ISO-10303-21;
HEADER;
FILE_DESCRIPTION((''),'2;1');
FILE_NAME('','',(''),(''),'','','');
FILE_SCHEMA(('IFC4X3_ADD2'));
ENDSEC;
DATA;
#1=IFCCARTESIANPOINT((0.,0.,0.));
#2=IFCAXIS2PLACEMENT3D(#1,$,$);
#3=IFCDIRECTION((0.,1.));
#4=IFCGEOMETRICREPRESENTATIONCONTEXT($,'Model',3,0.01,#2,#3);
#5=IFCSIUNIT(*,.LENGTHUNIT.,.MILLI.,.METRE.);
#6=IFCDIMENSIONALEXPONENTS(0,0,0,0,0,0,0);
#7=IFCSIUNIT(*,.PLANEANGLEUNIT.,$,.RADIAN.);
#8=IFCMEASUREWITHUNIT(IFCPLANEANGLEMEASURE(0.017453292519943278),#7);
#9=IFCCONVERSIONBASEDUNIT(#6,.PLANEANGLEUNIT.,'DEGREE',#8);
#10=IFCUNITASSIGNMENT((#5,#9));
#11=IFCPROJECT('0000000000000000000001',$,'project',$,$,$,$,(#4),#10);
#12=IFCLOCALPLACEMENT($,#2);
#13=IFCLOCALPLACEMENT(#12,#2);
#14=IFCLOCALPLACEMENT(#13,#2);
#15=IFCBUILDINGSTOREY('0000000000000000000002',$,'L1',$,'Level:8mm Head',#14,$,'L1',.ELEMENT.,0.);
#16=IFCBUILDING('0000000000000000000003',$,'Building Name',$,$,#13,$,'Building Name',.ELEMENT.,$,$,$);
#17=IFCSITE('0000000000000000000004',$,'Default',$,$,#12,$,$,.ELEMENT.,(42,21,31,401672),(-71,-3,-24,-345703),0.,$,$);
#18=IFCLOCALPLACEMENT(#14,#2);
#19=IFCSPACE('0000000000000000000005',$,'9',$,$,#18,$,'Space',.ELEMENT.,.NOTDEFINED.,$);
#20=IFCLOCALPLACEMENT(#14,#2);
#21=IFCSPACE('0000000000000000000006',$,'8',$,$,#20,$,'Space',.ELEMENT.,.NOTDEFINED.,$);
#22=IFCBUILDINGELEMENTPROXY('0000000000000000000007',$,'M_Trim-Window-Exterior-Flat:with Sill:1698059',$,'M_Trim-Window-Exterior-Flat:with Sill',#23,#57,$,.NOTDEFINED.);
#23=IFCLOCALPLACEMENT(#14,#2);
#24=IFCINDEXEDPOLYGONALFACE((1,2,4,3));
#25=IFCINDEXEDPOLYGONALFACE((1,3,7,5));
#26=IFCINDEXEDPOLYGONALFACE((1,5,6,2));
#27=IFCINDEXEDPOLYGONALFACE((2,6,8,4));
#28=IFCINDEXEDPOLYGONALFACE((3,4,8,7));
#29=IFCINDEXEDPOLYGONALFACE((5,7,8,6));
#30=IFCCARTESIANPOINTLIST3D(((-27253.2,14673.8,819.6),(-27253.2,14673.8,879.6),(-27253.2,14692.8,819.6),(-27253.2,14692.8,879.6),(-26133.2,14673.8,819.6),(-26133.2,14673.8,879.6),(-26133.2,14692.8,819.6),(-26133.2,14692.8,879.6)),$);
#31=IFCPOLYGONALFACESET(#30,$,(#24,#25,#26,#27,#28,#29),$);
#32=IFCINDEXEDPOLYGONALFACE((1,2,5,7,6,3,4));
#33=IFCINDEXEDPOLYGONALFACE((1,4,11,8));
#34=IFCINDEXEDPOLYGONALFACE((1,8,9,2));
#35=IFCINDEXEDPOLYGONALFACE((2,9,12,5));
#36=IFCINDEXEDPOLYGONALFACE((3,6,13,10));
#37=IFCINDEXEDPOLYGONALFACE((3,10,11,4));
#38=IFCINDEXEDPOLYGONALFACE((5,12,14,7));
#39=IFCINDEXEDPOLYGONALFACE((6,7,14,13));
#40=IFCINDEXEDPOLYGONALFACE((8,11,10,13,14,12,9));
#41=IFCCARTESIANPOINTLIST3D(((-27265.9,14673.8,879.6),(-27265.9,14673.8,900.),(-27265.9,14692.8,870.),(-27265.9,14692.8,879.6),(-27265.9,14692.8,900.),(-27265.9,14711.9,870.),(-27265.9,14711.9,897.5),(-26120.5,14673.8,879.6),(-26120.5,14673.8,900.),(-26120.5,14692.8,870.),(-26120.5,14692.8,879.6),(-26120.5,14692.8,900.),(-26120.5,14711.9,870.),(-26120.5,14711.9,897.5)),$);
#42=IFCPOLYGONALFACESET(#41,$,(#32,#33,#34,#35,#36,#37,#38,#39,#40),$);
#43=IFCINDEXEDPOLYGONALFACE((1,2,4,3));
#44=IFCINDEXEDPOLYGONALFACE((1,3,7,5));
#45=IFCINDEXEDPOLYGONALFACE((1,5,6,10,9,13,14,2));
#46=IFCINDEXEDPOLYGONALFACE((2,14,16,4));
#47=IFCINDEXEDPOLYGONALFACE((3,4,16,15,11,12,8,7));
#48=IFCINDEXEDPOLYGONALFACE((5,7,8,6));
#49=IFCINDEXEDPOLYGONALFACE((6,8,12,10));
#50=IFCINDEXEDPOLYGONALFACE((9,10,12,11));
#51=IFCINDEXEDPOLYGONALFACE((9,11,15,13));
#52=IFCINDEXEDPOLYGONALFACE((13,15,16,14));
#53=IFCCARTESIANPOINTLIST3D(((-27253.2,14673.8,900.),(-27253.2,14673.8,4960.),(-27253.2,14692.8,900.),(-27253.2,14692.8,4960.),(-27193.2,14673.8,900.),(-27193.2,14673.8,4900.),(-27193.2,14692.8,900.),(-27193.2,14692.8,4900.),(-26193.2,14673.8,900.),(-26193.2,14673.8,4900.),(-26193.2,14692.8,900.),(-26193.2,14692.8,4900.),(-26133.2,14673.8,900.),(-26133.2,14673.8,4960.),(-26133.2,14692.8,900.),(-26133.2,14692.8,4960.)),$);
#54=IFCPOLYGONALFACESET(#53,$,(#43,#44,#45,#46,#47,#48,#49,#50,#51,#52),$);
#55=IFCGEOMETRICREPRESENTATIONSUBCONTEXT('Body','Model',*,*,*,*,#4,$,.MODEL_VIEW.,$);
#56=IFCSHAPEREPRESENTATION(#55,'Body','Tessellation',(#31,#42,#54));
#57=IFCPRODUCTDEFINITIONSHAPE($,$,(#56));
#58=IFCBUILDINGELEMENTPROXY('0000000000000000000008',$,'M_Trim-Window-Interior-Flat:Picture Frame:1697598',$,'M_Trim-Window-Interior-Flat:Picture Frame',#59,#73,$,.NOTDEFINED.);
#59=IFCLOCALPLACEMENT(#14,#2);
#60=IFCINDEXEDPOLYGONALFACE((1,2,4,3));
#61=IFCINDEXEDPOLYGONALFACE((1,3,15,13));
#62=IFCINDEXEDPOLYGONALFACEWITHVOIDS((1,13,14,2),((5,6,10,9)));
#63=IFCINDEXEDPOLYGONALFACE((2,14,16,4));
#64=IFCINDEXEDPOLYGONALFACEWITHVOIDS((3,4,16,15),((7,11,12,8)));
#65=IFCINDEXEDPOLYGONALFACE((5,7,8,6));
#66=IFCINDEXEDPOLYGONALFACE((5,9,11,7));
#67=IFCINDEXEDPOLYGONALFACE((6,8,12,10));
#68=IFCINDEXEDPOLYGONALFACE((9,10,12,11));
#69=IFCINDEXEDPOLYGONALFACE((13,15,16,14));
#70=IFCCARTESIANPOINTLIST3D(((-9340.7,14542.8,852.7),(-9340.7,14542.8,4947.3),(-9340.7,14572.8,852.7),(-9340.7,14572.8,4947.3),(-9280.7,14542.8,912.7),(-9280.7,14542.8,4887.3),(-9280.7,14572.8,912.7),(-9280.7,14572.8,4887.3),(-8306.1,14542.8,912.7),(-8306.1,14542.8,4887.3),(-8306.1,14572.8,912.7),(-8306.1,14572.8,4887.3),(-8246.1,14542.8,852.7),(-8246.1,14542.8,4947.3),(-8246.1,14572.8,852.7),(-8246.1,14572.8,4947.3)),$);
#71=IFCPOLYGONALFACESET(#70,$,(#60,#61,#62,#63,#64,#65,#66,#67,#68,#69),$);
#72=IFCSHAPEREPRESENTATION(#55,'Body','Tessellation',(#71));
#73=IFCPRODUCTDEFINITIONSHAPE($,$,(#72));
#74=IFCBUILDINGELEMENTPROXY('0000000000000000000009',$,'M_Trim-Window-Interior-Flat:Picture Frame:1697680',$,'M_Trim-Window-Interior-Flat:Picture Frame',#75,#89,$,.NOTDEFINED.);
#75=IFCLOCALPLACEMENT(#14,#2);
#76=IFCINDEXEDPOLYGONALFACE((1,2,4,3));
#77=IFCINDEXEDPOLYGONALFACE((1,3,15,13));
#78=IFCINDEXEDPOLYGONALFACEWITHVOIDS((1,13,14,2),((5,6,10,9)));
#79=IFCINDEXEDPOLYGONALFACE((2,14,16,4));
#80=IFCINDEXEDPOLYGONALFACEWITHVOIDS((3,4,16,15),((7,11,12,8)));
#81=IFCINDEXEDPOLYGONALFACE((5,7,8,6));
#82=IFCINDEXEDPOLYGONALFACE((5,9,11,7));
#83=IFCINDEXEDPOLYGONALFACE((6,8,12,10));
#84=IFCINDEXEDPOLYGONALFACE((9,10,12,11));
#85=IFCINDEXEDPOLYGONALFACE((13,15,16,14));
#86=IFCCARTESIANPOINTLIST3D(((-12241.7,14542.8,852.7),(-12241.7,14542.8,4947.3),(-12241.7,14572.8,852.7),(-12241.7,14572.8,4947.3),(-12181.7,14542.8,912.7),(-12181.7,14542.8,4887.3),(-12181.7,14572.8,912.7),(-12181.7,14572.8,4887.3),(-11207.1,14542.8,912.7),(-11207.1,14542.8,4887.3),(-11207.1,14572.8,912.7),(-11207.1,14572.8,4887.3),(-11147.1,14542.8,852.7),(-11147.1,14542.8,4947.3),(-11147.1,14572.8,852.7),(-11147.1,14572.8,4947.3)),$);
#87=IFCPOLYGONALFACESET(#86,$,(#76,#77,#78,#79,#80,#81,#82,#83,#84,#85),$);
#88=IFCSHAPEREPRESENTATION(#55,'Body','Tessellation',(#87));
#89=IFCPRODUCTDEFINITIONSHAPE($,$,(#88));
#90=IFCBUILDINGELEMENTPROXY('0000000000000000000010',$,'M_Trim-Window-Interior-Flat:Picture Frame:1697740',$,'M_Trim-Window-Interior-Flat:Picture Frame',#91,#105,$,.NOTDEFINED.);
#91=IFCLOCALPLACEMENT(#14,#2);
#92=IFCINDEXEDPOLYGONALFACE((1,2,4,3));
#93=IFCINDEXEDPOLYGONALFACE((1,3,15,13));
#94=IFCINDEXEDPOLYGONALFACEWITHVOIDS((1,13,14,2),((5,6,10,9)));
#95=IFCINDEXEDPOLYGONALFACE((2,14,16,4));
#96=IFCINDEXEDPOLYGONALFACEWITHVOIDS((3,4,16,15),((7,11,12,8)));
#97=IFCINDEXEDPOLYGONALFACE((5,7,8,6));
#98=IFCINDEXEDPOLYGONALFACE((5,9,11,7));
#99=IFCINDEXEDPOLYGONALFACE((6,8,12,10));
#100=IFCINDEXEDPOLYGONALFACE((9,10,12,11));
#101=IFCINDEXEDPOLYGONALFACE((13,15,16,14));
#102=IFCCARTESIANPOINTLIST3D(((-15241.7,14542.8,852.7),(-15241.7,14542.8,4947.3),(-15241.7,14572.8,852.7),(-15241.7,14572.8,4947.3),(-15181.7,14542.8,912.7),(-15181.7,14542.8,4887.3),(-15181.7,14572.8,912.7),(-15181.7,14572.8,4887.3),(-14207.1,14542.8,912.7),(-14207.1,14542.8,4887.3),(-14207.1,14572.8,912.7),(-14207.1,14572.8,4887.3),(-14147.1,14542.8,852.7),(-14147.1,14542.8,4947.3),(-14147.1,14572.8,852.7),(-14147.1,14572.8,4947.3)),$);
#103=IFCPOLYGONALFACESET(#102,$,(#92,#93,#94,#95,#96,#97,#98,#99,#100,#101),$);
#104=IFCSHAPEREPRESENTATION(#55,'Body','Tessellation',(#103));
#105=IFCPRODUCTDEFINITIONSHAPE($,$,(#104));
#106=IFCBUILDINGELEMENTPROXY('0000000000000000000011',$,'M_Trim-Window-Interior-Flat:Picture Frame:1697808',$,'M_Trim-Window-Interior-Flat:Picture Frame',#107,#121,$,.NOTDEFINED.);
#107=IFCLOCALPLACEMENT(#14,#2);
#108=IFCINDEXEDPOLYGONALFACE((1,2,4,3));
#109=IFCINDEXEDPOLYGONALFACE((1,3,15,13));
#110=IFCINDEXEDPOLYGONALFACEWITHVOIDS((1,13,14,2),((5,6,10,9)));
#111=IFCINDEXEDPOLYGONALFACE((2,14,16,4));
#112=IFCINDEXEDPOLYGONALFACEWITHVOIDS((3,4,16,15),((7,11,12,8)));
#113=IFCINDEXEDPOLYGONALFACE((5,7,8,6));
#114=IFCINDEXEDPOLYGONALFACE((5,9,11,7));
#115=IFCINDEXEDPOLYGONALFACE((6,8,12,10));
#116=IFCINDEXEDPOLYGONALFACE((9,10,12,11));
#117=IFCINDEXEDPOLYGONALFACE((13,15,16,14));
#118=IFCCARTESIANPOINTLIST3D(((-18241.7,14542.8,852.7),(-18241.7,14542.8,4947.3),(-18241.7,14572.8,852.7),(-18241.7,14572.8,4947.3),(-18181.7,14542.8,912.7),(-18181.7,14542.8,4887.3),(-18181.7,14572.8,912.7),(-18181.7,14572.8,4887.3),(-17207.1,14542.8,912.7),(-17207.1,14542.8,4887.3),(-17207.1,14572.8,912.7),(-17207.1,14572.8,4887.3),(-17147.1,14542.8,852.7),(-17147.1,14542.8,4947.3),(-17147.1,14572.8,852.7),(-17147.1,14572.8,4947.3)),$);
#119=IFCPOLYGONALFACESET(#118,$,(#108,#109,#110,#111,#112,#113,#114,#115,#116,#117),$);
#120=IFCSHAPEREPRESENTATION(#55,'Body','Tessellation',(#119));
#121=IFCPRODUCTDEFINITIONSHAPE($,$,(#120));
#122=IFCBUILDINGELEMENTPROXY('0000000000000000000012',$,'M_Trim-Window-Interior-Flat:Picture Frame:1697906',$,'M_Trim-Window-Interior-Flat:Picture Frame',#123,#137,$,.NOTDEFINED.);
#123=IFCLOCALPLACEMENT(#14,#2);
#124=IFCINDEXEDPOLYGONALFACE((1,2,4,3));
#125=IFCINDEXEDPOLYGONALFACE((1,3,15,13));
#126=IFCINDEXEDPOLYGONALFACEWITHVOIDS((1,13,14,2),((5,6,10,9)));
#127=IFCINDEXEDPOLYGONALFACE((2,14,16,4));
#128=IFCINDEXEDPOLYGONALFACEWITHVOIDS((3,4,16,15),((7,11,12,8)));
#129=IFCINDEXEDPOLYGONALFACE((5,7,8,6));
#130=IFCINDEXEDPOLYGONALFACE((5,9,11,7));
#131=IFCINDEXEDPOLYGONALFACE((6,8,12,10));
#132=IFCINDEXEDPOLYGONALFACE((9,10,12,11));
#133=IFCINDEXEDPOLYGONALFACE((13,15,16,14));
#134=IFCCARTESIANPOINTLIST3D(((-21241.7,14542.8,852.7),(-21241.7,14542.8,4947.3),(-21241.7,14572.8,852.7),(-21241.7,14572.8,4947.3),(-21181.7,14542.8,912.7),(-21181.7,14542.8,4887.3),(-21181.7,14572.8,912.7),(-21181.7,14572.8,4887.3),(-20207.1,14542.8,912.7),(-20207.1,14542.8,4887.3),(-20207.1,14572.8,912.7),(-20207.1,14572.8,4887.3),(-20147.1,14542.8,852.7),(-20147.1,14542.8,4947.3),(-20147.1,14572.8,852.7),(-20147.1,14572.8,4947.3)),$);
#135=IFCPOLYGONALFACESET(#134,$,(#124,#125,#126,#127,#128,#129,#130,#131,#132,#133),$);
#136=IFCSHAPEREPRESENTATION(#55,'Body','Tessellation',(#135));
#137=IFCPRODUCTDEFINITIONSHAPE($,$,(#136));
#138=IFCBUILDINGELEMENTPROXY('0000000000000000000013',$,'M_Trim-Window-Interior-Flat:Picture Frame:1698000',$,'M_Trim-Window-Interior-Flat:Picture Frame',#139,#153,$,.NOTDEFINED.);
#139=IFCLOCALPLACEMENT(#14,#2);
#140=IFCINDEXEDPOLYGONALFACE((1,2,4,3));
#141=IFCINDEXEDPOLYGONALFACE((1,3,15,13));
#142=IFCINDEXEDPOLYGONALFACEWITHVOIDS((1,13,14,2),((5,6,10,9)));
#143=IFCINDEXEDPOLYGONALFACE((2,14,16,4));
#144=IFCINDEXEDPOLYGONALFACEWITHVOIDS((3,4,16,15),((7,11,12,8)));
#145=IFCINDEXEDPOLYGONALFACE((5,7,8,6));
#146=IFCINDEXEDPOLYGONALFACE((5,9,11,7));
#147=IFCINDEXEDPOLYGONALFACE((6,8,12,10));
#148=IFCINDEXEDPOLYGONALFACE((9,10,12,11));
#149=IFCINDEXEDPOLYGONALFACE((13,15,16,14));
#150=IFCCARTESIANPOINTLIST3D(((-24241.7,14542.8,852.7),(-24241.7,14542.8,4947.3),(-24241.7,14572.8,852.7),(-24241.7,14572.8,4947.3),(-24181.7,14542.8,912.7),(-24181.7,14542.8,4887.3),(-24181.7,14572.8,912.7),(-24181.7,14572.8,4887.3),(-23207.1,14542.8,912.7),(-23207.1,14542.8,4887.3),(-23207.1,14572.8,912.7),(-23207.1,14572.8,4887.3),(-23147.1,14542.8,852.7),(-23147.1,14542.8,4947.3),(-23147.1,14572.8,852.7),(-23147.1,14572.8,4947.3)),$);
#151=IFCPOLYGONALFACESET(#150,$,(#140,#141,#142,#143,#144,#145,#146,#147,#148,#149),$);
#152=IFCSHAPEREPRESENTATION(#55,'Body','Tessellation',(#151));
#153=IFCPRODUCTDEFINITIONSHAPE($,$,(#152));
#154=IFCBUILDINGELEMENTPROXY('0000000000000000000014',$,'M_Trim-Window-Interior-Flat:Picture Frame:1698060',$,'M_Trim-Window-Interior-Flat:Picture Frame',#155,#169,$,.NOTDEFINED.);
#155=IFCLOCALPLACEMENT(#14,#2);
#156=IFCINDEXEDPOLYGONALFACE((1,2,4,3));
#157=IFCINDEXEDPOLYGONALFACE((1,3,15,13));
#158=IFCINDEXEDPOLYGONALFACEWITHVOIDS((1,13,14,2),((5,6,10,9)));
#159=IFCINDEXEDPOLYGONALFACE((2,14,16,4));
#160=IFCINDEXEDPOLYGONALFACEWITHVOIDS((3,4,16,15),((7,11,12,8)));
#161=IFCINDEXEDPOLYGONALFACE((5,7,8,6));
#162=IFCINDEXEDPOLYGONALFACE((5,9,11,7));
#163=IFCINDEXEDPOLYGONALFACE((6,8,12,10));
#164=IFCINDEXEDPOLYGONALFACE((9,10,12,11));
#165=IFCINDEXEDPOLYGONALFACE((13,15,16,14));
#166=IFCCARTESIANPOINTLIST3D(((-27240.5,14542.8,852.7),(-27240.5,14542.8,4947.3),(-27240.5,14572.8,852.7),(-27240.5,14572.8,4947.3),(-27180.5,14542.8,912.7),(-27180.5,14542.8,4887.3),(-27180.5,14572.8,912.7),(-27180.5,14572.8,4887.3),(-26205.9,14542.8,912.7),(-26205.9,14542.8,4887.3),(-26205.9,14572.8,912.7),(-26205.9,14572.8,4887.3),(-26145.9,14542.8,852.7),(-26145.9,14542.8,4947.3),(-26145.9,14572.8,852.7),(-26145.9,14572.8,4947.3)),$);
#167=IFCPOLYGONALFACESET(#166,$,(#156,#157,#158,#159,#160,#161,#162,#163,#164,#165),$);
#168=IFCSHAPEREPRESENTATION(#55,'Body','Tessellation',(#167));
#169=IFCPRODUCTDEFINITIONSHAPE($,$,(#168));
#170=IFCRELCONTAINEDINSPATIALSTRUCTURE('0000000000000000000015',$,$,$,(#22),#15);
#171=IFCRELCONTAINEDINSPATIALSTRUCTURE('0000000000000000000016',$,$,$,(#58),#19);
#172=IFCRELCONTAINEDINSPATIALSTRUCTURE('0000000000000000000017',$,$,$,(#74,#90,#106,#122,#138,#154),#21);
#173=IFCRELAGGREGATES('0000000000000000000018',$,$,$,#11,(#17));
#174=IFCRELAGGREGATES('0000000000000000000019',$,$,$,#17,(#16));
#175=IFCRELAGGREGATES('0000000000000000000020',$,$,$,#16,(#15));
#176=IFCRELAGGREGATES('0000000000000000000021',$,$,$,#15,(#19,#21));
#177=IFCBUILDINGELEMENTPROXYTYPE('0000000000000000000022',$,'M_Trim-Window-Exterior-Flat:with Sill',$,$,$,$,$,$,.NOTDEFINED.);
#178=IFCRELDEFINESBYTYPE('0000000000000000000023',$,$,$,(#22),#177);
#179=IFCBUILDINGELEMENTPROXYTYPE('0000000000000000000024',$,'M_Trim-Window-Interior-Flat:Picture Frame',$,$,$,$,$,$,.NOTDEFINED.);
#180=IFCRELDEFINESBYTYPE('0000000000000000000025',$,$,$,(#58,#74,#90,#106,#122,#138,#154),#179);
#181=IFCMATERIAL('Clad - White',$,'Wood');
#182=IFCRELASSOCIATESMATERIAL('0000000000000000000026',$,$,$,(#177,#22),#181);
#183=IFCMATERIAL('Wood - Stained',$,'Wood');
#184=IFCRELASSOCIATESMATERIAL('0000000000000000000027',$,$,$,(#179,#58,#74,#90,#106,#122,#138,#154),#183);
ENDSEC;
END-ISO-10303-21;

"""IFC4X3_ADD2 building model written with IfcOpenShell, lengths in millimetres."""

from ifc_helpers import new_model, entity, si_unit, converted_unit, direction, frame, frame_2d, origin, place, context, subcontext, project, spatial, polyline, rectangle, outline, extrude, source, transform, mapped, material, type_object, type_shapes, element, save


model = new_model("IFC4X3_ADD2")

# Units and contexts
model_context = context("Model", 3, precision=0.01, world=origin(), true_north=direction((0.0, 1.0)))
body_context = subcontext(model_context, "Body", "Model", "MODEL_VIEW")
ifc_project = project(units=[si_unit("LENGTHUNIT", "METRE", prefix="MILLI"), converted_unit("PLANEANGLEUNIT", "DEGREE", entity("IfcPlaneAngleMeasure", 0.017453292519943278), si_unit("PLANEANGLEUNIT", "RADIAN"), dimensions=[0, 0, 0, 0, 0, 0, 0])], contexts=[model_context])

# Site, building, storey
site_placement = place(None, origin())
site = spatial("IfcSite", under=ifc_project, at=site_placement, Name="Default", CompositionType="ELEMENT", RefLatitude=(42, 21, 31, 401672), RefLongitude=(-71, -3, -24, -345703), RefElevation=0.0)
building_placement = place(site_placement, origin())
building = spatial("IfcBuilding", under=site, at=building_placement, Name="Building Name", LongName="Building Name", CompositionType="ELEMENT")
storey_placement = place(building_placement, origin())
storey = spatial("IfcBuildingStorey", under=building, at=storey_placement, Name="L1", ObjectType="Level:8mm Head", LongName="L1", CompositionType="ELEMENT", Elevation=0.0)

# Building element proxy
ifc_material_1 = material(Name="Clad - White", Category="Wood")
ifc_material_2 = material(Name="Wood - Stained", Category="Wood")
building_element_proxy_type_1 = type_object("IfcBuildingElementProxyType", Name="M_Trim-Window-Exterior-Flat:with Sill", PredefinedType="NOTDEFINED", material=ifc_material_1)
shared_shape_1 = source(origin(), body_context, "Body", "SweptSolid", [
    extrude(rectangle(XDim=1120.0, YDim=60.0, at=frame_2d((0.0, 0.0), x_axis=(1.0, 0.0))), frame((0.0, -4050.4, 0.0), z_axis=(0.0, 0.0, 1.0), x_axis=(-1.0, 0.0, 0.0)), (0.0, 0.0, 1.0), 19.0),
    extrude(outline(polyline([(-19.0, -15.2), (0.0, -15.2), (0.0, -5.7), (19.0, -5.7), (19.0, 14.8), (0.0, 14.8), (-19.0, 12.3), (-19.0, -15.2)])), frame((-572.7, -4014.8, 19.0), z_axis=(1.0, 0.0, 0.0), x_axis=(0.0, 0.0, -1.0)), (0.0, 0.0, 1.0), 1145.4),
    extrude(outline(polyline([(-2045.0, -560.0), (2015.0, -560.0), (2015.0, -500.0), (-1985.0, -500.0), (-1985.0, 500.0), (2015.0, 500.0), (2015.0, 560.0), (-2045.0, 560.0), (-2045.0, -560.0)])), frame((0.0, -1985.0, 0.0), z_axis=(0.0, 0.0, 1.0), x_axis=(0.0, -1.0, 0.0)), (0.0, 0.0, 1.0), 19.0),
])
type_shapes(building_element_proxy_type_1, [shared_shape_1])
for number, where, z_axis, x_axis, name in (
    (1, (-26693.2, 14673.8, 4900.0), (0.0, 1.0, 0.0), (-1.0, 0.0, 0.0), "M_Trim-Window-Exterior-Flat:with Sill:1698059"),
):
    element("IfcBuildingElementProxy", number, at=place(storey_placement, frame(where, z_axis=z_axis, x_axis=x_axis)), inside=storey, type_object=building_element_proxy_type_1, material=ifc_material_1, Name=name, ObjectType="M_Trim-Window-Exterior-Flat:with Sill", PredefinedType="NOTDEFINED", context=body_context, shape_type="MappedRepresentation", body=[
        mapped(shared_shape_1, transform((0.0, 0.0, 0.0), scale=1.0)),
    ])

# Shared definitions
space_1_placement = place(storey_placement, origin())
space_1 = spatial("IfcSpace", under=storey, at=space_1_placement, Name="9", LongName="Space", CompositionType="ELEMENT", PredefinedType="NOTDEFINED")

# Building element proxy
building_element_proxy_type_2 = type_object("IfcBuildingElementProxyType", Name="M_Trim-Window-Interior-Flat:Picture Frame", PredefinedType="NOTDEFINED", material=ifc_material_2)
shared_shape_2 = source(origin(), body_context, "Body", "SweptSolid", [
    extrude(outline(polyline([(-547.3, -2047.3), (547.3, -2047.3), (547.3, 2047.3), (-547.3, 2047.3), (-547.3, -2047.3)]), holes=[polyline([(-487.3, -1987.3), (-487.3, 1987.3), (487.3, 1987.3), (487.3, -1987.3), (-487.3, -1987.3)])]), frame((0.0, -2000.0, 0.0), z_axis=(0.0, 0.0, 1.0), x_axis=(-1.0, 0.0, 0.0)), (0.0, 0.0, 1.0), 30.0),
])
type_shapes(building_element_proxy_type_2, [shared_shape_2])
proxy_1_placement = place(space_1_placement, frame((-8793.4, 14572.8, 4900.0), z_axis=(0.0, -1.0, 0.0), x_axis=(1.0, 0.0, 0.0)))
element("IfcBuildingElementProxy", 2, at=proxy_1_placement, inside=space_1, type_object=building_element_proxy_type_2, material=ifc_material_2, Name="M_Trim-Window-Interior-Flat:Picture Frame:1697598", ObjectType="M_Trim-Window-Interior-Flat:Picture Frame", PredefinedType="NOTDEFINED", context=body_context, shape_type="MappedRepresentation", body=[
    mapped(shared_shape_2, transform((0.0, 0.0, 0.0), scale=1.0)),
])

# Shared definitions
space_2_placement = place(storey_placement, origin())
space_2 = spatial("IfcSpace", under=storey, at=space_2_placement, Name="8", LongName="Space", CompositionType="ELEMENT", PredefinedType="NOTDEFINED")

# Building element proxies
for number, where, z_axis, x_axis, name in (
    (3, (-11694.4, 14572.8, 4900.0), (0.0, -1.0, 0.0), (1.0, 0.0, 0.0), "M_Trim-Window-Interior-Flat:Picture Frame:1697680"),
    (4, (-14694.4, 14572.8, 4900.0), (0.0, -1.0, 0.0), (1.0, 0.0, 0.0), "M_Trim-Window-Interior-Flat:Picture Frame:1697740"),
    (5, (-17694.4, 14572.8, 4900.0), (0.0, -1.0, 0.0), (1.0, 0.0, 0.0), "M_Trim-Window-Interior-Flat:Picture Frame:1697808"),
    (6, (-20694.4, 14572.8, 4900.0), (0.0, -1.0, 0.0), (1.0, 0.0, 0.0), "M_Trim-Window-Interior-Flat:Picture Frame:1697906"),
    (7, (-23694.4, 14572.8, 4900.0), (0.0, -1.0, 0.0), (1.0, 0.0, 0.0), "M_Trim-Window-Interior-Flat:Picture Frame:1698000"),
    (8, (-26693.2, 14572.8, 4900.0), (0.0, -1.0, 0.0), (1.0, 0.0, 0.0), "M_Trim-Window-Interior-Flat:Picture Frame:1698060"),
):
    element("IfcBuildingElementProxy", number, at=place(space_2_placement, frame(where, z_axis=z_axis, x_axis=x_axis)), inside=space_2, type_object=building_element_proxy_type_2, material=ifc_material_2, Name=name, ObjectType="M_Trim-Window-Interior-Flat:Picture Frame", PredefinedType="NOTDEFINED", context=body_context, shape_type="MappedRepresentation", body=[
        mapped(shared_shape_2, transform((0.0, 0.0, 0.0), scale=1.0)),
    ])

save(model, "model.ifc")
